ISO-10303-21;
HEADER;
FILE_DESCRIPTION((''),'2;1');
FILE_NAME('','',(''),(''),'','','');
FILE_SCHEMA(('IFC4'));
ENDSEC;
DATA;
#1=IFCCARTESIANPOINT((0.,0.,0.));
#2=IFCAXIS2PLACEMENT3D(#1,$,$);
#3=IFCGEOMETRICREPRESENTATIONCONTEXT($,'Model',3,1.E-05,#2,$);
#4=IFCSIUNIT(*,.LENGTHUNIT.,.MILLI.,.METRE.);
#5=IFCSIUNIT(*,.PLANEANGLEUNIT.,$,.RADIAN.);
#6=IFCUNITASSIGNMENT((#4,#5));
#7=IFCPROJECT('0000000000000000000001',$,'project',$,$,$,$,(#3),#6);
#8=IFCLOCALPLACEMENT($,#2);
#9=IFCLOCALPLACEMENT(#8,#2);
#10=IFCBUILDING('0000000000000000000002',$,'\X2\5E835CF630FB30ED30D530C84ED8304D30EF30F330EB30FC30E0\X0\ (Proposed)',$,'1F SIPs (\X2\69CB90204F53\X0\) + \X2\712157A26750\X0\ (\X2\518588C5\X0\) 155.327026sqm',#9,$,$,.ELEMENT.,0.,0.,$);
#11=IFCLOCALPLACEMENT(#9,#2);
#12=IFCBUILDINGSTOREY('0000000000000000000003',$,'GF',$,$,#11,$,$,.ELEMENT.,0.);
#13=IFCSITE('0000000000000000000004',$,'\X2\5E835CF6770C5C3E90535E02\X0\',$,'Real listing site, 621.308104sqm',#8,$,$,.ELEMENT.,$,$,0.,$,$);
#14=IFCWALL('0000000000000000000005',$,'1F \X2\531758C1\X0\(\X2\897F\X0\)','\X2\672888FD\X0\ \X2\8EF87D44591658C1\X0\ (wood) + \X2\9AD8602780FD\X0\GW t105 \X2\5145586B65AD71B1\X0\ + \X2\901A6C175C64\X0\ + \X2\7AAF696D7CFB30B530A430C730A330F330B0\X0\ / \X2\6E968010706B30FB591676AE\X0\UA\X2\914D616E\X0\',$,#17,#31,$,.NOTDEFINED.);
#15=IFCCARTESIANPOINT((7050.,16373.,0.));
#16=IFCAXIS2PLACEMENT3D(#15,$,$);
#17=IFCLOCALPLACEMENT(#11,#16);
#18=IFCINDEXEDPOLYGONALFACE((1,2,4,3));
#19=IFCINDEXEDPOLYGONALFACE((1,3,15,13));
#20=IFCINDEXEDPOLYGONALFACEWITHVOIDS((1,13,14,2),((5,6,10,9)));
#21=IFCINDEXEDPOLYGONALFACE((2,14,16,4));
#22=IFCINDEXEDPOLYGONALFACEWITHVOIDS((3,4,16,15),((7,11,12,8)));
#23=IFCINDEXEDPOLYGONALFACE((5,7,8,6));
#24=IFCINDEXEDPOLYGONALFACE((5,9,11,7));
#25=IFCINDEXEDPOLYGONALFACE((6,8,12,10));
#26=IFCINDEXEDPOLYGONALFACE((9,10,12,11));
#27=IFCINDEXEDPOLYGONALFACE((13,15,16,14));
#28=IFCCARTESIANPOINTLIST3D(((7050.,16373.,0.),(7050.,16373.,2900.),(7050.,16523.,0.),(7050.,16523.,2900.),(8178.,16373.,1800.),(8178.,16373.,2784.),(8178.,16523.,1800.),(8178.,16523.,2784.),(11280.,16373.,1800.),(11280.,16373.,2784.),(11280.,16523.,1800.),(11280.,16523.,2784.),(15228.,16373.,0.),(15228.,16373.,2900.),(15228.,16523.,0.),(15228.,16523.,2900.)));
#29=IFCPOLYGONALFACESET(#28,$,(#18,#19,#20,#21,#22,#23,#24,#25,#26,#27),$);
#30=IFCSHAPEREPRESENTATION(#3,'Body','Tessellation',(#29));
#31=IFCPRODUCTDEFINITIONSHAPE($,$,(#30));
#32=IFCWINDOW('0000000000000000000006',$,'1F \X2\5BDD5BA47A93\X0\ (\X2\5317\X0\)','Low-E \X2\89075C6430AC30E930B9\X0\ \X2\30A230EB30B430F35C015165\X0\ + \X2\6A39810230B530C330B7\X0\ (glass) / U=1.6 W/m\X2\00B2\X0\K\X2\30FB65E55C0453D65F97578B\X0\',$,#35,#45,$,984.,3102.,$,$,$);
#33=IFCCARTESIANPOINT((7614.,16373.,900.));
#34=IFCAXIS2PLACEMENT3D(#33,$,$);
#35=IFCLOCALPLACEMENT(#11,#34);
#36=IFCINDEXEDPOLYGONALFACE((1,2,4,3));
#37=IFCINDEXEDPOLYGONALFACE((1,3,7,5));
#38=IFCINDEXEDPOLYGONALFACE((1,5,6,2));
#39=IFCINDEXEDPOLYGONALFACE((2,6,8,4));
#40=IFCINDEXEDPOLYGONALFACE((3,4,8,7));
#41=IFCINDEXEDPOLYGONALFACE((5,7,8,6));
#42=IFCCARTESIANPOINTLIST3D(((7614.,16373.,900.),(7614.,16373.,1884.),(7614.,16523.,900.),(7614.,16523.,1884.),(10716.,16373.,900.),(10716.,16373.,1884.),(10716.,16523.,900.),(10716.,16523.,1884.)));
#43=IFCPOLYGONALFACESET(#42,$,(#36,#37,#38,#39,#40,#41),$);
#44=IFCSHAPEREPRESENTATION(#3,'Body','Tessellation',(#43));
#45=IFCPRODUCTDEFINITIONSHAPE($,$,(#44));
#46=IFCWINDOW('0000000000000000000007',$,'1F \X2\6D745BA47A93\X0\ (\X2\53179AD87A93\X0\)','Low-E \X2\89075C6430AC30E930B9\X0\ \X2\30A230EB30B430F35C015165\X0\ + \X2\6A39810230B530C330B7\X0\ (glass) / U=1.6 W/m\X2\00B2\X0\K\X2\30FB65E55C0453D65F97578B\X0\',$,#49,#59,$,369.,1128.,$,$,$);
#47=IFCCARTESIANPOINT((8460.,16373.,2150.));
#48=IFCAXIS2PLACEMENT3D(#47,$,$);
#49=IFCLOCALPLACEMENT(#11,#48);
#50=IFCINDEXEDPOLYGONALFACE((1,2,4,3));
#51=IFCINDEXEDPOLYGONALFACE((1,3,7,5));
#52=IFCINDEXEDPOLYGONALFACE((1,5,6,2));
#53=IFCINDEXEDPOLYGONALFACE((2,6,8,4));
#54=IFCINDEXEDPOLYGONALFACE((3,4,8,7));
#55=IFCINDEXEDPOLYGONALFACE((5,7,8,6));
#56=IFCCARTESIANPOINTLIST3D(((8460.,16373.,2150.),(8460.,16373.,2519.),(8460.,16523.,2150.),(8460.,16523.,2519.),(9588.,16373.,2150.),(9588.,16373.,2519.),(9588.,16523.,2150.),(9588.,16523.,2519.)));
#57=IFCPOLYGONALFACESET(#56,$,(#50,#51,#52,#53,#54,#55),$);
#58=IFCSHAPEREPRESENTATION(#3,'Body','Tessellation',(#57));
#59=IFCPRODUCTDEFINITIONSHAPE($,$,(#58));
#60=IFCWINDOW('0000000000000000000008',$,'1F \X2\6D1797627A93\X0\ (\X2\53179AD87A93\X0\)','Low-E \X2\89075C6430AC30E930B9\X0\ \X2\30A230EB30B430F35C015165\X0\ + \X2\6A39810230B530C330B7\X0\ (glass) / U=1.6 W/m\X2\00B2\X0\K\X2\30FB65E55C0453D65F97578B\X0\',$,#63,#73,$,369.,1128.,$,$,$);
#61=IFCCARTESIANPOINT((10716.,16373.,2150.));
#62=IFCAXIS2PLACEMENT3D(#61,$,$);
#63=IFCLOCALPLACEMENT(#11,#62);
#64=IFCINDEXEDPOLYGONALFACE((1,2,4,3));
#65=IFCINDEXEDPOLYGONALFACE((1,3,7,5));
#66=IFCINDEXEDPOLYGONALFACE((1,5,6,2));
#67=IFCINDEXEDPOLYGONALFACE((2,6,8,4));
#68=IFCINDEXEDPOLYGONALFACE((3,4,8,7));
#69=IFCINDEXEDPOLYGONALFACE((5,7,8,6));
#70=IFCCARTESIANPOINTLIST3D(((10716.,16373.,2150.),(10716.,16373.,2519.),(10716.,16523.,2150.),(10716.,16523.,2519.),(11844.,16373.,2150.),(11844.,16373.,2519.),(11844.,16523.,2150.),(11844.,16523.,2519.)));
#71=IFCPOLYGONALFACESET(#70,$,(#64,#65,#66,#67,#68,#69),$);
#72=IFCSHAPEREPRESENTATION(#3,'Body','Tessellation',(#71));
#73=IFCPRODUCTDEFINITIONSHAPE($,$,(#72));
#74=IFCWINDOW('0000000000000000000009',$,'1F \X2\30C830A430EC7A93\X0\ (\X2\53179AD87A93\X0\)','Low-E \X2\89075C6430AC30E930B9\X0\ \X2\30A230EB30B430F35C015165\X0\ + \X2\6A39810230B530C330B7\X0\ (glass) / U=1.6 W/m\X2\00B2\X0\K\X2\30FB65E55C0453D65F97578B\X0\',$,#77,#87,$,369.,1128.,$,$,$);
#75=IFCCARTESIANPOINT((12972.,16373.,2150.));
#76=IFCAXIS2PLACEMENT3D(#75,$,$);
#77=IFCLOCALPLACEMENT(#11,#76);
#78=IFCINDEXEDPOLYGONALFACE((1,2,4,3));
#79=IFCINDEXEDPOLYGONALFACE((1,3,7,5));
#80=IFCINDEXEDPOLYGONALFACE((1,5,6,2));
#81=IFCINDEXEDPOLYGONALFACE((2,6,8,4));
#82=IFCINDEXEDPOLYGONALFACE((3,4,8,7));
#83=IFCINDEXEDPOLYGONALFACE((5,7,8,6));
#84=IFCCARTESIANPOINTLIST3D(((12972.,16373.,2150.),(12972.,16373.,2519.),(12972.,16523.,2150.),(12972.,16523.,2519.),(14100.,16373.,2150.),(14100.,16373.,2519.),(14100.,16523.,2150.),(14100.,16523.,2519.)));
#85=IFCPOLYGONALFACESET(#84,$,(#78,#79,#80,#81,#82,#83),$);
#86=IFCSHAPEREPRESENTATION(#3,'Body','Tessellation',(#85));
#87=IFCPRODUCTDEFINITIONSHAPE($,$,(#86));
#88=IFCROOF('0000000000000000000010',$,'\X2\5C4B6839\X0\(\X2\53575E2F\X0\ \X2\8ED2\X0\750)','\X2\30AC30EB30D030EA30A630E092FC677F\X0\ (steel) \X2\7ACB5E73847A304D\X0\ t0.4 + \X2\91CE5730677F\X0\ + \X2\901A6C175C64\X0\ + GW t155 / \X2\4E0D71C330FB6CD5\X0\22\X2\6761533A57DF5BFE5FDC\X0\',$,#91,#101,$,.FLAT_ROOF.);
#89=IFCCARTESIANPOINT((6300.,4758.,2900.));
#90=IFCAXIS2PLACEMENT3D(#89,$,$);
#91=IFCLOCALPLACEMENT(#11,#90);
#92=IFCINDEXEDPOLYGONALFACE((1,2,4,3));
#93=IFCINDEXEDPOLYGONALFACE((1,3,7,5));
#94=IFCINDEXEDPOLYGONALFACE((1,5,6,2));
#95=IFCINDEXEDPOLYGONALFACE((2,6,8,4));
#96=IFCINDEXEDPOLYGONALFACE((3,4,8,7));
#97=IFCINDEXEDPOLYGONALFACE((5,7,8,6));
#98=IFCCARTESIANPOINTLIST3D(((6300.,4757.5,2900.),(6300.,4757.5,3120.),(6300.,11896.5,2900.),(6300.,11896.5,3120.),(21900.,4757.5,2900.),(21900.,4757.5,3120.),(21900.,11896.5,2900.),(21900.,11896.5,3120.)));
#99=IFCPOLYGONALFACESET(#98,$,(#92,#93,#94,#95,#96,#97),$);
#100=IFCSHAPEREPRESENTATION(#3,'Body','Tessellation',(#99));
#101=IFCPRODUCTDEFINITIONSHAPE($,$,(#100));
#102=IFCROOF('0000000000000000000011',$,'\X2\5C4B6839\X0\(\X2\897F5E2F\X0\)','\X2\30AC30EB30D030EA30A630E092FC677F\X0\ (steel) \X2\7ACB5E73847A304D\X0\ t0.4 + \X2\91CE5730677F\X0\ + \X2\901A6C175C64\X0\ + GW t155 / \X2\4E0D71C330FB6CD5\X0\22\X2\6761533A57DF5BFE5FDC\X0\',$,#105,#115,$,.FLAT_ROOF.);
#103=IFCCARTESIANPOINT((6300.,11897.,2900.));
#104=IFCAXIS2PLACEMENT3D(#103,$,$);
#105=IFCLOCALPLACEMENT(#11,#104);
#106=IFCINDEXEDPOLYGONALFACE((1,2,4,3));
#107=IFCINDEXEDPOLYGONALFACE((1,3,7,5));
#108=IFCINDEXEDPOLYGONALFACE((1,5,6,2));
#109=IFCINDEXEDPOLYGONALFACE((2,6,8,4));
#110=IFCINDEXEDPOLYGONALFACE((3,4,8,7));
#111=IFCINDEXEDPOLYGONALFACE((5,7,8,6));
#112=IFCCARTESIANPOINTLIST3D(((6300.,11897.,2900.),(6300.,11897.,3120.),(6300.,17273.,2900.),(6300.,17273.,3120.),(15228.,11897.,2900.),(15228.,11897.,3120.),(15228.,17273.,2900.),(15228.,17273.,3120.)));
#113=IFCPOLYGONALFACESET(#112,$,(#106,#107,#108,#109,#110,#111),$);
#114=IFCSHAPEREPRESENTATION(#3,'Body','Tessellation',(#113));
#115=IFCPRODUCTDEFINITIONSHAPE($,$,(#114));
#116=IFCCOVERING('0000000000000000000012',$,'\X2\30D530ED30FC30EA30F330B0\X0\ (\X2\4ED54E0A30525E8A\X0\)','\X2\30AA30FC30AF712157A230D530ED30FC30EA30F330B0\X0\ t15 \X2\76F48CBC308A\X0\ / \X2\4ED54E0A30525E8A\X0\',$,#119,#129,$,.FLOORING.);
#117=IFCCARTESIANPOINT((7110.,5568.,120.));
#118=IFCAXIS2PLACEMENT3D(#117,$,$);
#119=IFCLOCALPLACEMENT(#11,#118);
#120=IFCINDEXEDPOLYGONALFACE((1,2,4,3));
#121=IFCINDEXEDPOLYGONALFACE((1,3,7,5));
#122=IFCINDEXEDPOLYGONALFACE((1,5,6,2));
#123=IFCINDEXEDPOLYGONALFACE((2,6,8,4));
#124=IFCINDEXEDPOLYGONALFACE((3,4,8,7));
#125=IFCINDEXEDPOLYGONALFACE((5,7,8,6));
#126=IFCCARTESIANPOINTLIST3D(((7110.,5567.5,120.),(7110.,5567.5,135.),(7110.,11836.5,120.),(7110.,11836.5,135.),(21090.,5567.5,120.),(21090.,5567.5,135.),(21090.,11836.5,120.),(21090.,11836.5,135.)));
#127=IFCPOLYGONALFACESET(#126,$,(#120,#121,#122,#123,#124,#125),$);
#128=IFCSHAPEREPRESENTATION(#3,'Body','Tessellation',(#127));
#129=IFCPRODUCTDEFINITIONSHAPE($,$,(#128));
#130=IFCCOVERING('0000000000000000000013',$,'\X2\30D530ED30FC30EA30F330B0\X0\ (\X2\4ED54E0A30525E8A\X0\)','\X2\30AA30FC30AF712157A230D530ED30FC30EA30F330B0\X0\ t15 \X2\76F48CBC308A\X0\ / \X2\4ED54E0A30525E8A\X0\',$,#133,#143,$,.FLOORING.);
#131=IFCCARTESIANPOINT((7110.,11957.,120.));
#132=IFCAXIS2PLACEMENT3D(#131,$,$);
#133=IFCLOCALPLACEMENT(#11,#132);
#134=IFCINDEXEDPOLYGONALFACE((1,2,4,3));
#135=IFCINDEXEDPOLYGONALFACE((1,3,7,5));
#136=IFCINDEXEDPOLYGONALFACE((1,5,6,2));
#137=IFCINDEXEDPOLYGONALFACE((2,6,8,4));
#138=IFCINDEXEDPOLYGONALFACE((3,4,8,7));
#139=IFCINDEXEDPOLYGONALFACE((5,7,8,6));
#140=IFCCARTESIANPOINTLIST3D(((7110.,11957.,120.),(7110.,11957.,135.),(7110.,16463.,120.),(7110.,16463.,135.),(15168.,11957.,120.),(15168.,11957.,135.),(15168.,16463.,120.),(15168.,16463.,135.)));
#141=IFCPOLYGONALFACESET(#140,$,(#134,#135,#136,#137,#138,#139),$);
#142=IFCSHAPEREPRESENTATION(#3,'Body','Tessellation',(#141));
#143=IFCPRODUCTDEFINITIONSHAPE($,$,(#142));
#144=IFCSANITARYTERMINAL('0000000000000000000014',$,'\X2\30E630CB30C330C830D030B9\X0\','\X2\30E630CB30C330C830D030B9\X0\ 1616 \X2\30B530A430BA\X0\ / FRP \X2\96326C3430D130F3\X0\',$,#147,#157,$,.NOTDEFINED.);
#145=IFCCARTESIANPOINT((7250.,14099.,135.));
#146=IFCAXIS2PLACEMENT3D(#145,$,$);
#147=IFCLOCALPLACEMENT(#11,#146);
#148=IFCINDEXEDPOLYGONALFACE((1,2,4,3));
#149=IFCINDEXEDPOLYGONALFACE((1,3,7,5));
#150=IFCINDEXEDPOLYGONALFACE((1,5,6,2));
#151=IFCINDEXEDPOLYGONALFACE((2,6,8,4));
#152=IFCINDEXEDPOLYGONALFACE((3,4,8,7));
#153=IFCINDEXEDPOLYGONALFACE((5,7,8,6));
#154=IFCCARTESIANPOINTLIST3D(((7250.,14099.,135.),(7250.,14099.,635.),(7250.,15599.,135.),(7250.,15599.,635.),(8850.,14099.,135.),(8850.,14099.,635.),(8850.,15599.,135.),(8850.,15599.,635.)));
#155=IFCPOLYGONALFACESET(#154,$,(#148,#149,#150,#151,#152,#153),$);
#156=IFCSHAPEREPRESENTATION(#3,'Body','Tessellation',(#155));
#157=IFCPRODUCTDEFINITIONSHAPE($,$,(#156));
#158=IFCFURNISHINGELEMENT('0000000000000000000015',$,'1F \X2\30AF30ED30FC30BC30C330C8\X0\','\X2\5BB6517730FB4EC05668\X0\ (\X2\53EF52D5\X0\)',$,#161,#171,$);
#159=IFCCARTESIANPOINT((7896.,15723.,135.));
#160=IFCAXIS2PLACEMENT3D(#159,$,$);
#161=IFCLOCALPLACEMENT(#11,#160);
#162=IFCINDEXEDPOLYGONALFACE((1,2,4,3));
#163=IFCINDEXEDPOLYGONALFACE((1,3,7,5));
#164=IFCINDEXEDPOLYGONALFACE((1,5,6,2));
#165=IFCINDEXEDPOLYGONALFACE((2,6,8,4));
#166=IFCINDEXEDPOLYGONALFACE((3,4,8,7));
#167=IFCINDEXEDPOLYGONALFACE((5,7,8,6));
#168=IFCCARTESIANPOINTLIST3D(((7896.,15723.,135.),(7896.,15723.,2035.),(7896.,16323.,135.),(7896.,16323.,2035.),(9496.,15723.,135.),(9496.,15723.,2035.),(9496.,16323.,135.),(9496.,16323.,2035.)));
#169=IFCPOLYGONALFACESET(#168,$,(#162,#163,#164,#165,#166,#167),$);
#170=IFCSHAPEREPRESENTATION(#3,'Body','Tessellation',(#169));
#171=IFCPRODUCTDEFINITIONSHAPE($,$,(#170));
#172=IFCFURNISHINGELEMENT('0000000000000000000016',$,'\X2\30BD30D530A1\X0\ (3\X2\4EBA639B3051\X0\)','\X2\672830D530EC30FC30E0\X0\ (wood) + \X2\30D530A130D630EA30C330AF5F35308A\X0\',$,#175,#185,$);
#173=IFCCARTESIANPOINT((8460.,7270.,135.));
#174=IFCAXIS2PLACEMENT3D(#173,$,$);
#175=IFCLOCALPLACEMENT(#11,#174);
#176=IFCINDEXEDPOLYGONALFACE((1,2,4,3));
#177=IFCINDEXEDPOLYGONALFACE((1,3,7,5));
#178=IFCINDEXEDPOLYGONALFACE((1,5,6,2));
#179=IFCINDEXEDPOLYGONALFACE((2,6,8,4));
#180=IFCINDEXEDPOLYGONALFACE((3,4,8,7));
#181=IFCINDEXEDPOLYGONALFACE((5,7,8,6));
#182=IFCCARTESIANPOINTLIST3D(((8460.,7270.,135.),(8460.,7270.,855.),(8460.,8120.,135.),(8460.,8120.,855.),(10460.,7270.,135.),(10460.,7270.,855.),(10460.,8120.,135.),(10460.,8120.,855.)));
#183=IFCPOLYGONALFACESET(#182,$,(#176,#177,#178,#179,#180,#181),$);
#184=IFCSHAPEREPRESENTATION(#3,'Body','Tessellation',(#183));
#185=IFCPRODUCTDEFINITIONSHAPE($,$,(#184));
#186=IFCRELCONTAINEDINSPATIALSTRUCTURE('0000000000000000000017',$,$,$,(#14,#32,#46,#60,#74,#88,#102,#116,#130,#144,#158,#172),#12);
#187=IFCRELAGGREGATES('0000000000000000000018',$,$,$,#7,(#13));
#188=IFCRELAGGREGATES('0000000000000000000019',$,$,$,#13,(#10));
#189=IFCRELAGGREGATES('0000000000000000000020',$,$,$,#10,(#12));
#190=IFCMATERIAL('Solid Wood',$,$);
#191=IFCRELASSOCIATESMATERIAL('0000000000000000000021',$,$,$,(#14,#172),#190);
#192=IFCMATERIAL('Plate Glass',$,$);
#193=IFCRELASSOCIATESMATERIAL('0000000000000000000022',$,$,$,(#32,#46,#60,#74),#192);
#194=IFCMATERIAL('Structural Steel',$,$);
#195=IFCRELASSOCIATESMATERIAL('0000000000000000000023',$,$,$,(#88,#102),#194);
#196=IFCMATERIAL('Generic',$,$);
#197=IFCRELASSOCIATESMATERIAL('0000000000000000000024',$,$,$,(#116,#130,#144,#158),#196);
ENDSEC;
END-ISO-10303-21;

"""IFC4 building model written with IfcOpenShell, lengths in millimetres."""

from ifc_helpers import new_model, si_unit, frame, frame_2d, origin, place, context, project, spatial, rectangle, extrude, material, element, fill, save


model = new_model("IFC4")

# Units and contexts
model_context = context("Model", 3, precision=1e-05, world=origin())
ifc_project = project(units=[si_unit("LENGTHUNIT", "METRE", prefix="MILLI"), si_unit("PLANEANGLEUNIT", "RADIAN")], contexts=[model_context])

# Site, building, storey
site_placement = place(None, origin())
site = spatial("IfcSite", under=ifc_project, at=site_placement, Name="広島県尾道市", ObjectType="Real listing site, 621.308104sqm", CompositionType="ELEMENT", RefElevation=0.0)
building_placement = place(site_placement, origin())
building = spatial("IfcBuilding", under=site, at=building_placement, Name="広島・ロフト付きワンルーム (Proposed)", ObjectType="1F SIPs (構造体) + 無垢材 (内装) 155.327026sqm", CompositionType="ELEMENT", ElevationOfRefHeight=0.0, ElevationOfTerrain=0.0)
storey_placement = place(building_placement, origin())
storey = spatial("IfcBuildingStorey", under=building, at=storey_placement, Name="GF", CompositionType="ELEMENT", Elevation=0.0)

# Shared definitions
ifc_material_1 = material(Name="Solid Wood")

# Shared definitions
ifc_material_2 = material(Name="Plate Glass")

# Wall, openings, windows
wall_1_placement = place(storey_placement, frame((7050.0, 16373.0, 0.0)))
wall_1 = element("IfcWall", 1, at=wall_1_placement, inside=storey, material=ifc_material_1, Name="1F 北壁(西)", Description="木製 軸組外壁 (wood) + 高性能GW t105 充填断熱 + 通気層 + 窯業系サイディング / 準耐火・外皮UA配慮", PredefinedType="NOTDEFINED", context=model_context, shape_type="SweptSolid", body=[
    extrude(rectangle(XDim=8178.0, YDim=150.0, at=frame_2d((4089.0, 75.0))), frame((7050.0, 16373.0, 0.0)), (0.0, 0.0, 1.0), 2900.0),
])
opening_1_placement = place(storey_placement, frame((7614.0, 16373.0, 900.0)))
opening_1 = element("IfcOpeningElement", 2, at=opening_1_placement, cuts=wall_1, PredefinedType="NOTDEFINED", context=model_context, shape_type="SweptSolid", body=[
    extrude(rectangle(XDim=3102.0, YDim=150.0, at=frame_2d((1551.0, 75.0))), frame((7614.0, 16373.0, 900.0)), (0.0, 0.0, 1.0), 984.0),
])
opening_2_placement = place(storey_placement, frame((8460.0, 16373.0, 2150.0)))
opening_2 = element("IfcOpeningElement", 3, at=opening_2_placement, cuts=wall_1, PredefinedType="NOTDEFINED", context=model_context, shape_type="SweptSolid", body=[
    extrude(rectangle(XDim=1128.0, YDim=150.0, at=frame_2d((564.0, 75.0))), frame((8460.0, 16373.0, 2150.0)), (0.0, 0.0, 1.0), 369.0),
])
opening_3_placement = place(storey_placement, frame((10716.0, 16373.0, 2150.0)))
opening_3 = element("IfcOpeningElement", 4, at=opening_3_placement, cuts=wall_1, PredefinedType="NOTDEFINED", context=model_context, shape_type="SweptSolid", body=[
    extrude(rectangle(XDim=1128.0, YDim=150.0, at=frame_2d((564.0, 75.0))), frame((10716.0, 16373.0, 2150.0)), (0.0, 0.0, 1.0), 369.0),
])
opening_4_placement = place(storey_placement, frame((12972.0, 16373.0, 2150.0)))
opening_4 = element("IfcOpeningElement", 5, at=opening_4_placement, cuts=wall_1, PredefinedType="NOTDEFINED", context=model_context, shape_type="SweptSolid", body=[
    extrude(rectangle(XDim=1128.0, YDim=150.0, at=frame_2d((564.0, 75.0))), frame((12972.0, 16373.0, 2150.0)), (0.0, 0.0, 1.0), 369.0),
])
window_1_placement = place(storey_placement, frame((7614.0, 16373.0, 900.0)))
window_1 = element("IfcWindow", 6, at=window_1_placement, inside=storey, material=ifc_material_2, Name="1F 寝室窓 (北)", Description="Low-E 複層ガラス アルゴン封入 + 樹脂サッシ (glass) / U=1.6 W/m²K・日射取得型", OverallHeight=984.0, OverallWidth=3102.0, context=model_context, shape_type="SweptSolid", body=[
    extrude(rectangle(XDim=3102.0, YDim=150.0, at=frame_2d((1551.0, 75.0))), frame((7614.0, 16373.0, 900.0)), (0.0, 0.0, 1.0), 984.0),
])
fill(opening_1, window_1)
window_2_placement = place(storey_placement, frame((8460.0, 16373.0, 2150.0)))
window_2 = element("IfcWindow", 7, at=window_2_placement, inside=storey, material=ifc_material_2, Name="1F 浴室窓 (北高窓)", Description="Low-E 複層ガラス アルゴン封入 + 樹脂サッシ (glass) / U=1.6 W/m²K・日射取得型", OverallHeight=369.0, OverallWidth=1128.0, context=model_context, shape_type="SweptSolid", body=[
    extrude(rectangle(XDim=1128.0, YDim=150.0, at=frame_2d((564.0, 75.0))), frame((8460.0, 16373.0, 2150.0)), (0.0, 0.0, 1.0), 369.0),
])
fill(opening_2, window_2)
window_3_placement = place(storey_placement, frame((10716.0, 16373.0, 2150.0)))
window_3 = element("IfcWindow", 8, at=window_3_placement, inside=storey, material=ifc_material_2, Name="1F 洗面窓 (北高窓)", Description="Low-E 複層ガラス アルゴン封入 + 樹脂サッシ (glass) / U=1.6 W/m²K・日射取得型", OverallHeight=369.0, OverallWidth=1128.0, context=model_context, shape_type="SweptSolid", body=[
    extrude(rectangle(XDim=1128.0, YDim=150.0, at=frame_2d((564.0, 75.0))), frame((10716.0, 16373.0, 2150.0)), (0.0, 0.0, 1.0), 369.0),
])
fill(opening_3, window_3)
window_4_placement = place(storey_placement, frame((12972.0, 16373.0, 2150.0)))
window_4 = element("IfcWindow", 9, at=window_4_placement, inside=storey, material=ifc_material_2, Name="1F トイレ窓 (北高窓)", Description="Low-E 複層ガラス アルゴン封入 + 樹脂サッシ (glass) / U=1.6 W/m²K・日射取得型", OverallHeight=369.0, OverallWidth=1128.0, context=model_context, shape_type="SweptSolid", body=[
    extrude(rectangle(XDim=1128.0, YDim=150.0, at=frame_2d((564.0, 75.0))), frame((12972.0, 16373.0, 2150.0)), (0.0, 0.0, 1.0), 369.0),
])
fill(opening_4, window_4)

# Roofs
ifc_material_3 = material(Name="Structural Steel")
roof_1_placement = place(storey_placement, frame((6300.0, 4758.0, 2900.0)))
element("IfcRoof", 10, at=roof_1_placement, inside=storey, material=ifc_material_3, Name="屋根(南帯 軒750)", Description="ガルバリウム鋼板 (steel) 立平葺き t0.4 + 野地板 + 通気層 + GW t155 / 不燃・法22条区域対応", PredefinedType="FLAT_ROOF", context=model_context, shape_type="SweptSolid", body=[
    extrude(rectangle(XDim=15600.0, YDim=7139.0, at=frame_2d((7800.0, 3569.0))), frame((6300.0, 4758.0, 2900.0)), (0.0, 0.0, 1.0), 220.0),
])
roof_2_placement = place(storey_placement, frame((6300.0, 11897.0, 2900.0)))
element("IfcRoof", 11, at=roof_2_placement, inside=storey, material=ifc_material_3, Name="屋根(西帯)", Description="ガルバリウム鋼板 (steel) 立平葺き t0.4 + 野地板 + 通気層 + GW t155 / 不燃・法22条区域対応", PredefinedType="FLAT_ROOF", context=model_context, shape_type="SweptSolid", body=[
    extrude(rectangle(XDim=8928.0, YDim=5376.0, at=frame_2d((4464.0, 2688.0))), frame((6300.0, 11897.0, 2900.0)), (0.0, 0.0, 1.0), 220.0),
])

# Coverings
ifc_material_4 = material(Name="Generic")
covering_1_placement = place(storey_placement, frame((7110.0, 5568.0, 120.0)))
element("IfcCovering", 12, at=covering_1_placement, inside=storey, material=ifc_material_4, Name="フローリング (仕上げ床)", Description="オーク無垢フローリング t15 直貼り / 仕上げ床", PredefinedType="FLOORING", context=model_context, shape_type="SweptSolid", body=[
    extrude(rectangle(XDim=13980.0, YDim=6269.0, at=frame_2d((6990.0, 3134.0))), frame((7110.0, 5568.0, 120.0)), (0.0, 0.0, 1.0), 15.0),
])
covering_2_placement = place(storey_placement, frame((7110.0, 11957.0, 120.0)))
element("IfcCovering", 13, at=covering_2_placement, inside=storey, material=ifc_material_4, Name="フローリング (仕上げ床)", Description="オーク無垢フローリング t15 直貼り / 仕上げ床", PredefinedType="FLOORING", context=model_context, shape_type="SweptSolid", body=[
    extrude(rectangle(XDim=8058.0, YDim=4506.0, at=frame_2d((4029.0, 2253.0))), frame((7110.0, 11957.0, 120.0)), (0.0, 0.0, 1.0), 15.0),
])

# Sanitary terminal
sanitary_terminal_placement = place(storey_placement, frame((7250.0, 14099.0, 135.0)))
element("IfcSanitaryTerminal", 14, at=sanitary_terminal_placement, inside=storey, material=ifc_material_4, Name="ユニットバス", Description="ユニットバス 1616 サイズ / FRP 防水パン", PredefinedType="NOTDEFINED", context=model_context, shape_type="SweptSolid", body=[
    extrude(rectangle(XDim=1600.0, YDim=1500.0, at=frame_2d((800.0, 750.0))), frame((7250.0, 14099.0, 135.0)), (0.0, 0.0, 1.0), 500.0),
])

# Furnishing elements
furnishing_1_placement = place(storey_placement, frame((7896.0, 15723.0, 135.0)))
element("IfcFurnishingElement", 15, at=furnishing_1_placement, inside=storey, material=ifc_material_4, Name="1F クローゼット", Description="家具・什器 (可動)", context=model_context, shape_type="SweptSolid", body=[
    extrude(rectangle(XDim=1600.0, YDim=600.0, at=frame_2d((800.0, 300.0))), frame((7896.0, 15723.0, 135.0)), (0.0, 0.0, 1.0), 1900.0),
])
furnishing_2_placement = place(storey_placement, frame((8460.0, 7270.0, 135.0)))
element("IfcFurnishingElement", 16, at=furnishing_2_placement, inside=storey, material=ifc_material_1, Name="ソファ (3人掛け)", Description="木フレーム (wood) + ファブリック張り", context=model_context, shape_type="SweptSolid", body=[
    extrude(rectangle(XDim=2000.0, YDim=850.0, at=frame_2d((1000.0, 425.0))), frame((8460.0, 7270.0, 135.0)), (0.0, 0.0, 1.0), 720.0),
])

save(model, "model.ifc")
